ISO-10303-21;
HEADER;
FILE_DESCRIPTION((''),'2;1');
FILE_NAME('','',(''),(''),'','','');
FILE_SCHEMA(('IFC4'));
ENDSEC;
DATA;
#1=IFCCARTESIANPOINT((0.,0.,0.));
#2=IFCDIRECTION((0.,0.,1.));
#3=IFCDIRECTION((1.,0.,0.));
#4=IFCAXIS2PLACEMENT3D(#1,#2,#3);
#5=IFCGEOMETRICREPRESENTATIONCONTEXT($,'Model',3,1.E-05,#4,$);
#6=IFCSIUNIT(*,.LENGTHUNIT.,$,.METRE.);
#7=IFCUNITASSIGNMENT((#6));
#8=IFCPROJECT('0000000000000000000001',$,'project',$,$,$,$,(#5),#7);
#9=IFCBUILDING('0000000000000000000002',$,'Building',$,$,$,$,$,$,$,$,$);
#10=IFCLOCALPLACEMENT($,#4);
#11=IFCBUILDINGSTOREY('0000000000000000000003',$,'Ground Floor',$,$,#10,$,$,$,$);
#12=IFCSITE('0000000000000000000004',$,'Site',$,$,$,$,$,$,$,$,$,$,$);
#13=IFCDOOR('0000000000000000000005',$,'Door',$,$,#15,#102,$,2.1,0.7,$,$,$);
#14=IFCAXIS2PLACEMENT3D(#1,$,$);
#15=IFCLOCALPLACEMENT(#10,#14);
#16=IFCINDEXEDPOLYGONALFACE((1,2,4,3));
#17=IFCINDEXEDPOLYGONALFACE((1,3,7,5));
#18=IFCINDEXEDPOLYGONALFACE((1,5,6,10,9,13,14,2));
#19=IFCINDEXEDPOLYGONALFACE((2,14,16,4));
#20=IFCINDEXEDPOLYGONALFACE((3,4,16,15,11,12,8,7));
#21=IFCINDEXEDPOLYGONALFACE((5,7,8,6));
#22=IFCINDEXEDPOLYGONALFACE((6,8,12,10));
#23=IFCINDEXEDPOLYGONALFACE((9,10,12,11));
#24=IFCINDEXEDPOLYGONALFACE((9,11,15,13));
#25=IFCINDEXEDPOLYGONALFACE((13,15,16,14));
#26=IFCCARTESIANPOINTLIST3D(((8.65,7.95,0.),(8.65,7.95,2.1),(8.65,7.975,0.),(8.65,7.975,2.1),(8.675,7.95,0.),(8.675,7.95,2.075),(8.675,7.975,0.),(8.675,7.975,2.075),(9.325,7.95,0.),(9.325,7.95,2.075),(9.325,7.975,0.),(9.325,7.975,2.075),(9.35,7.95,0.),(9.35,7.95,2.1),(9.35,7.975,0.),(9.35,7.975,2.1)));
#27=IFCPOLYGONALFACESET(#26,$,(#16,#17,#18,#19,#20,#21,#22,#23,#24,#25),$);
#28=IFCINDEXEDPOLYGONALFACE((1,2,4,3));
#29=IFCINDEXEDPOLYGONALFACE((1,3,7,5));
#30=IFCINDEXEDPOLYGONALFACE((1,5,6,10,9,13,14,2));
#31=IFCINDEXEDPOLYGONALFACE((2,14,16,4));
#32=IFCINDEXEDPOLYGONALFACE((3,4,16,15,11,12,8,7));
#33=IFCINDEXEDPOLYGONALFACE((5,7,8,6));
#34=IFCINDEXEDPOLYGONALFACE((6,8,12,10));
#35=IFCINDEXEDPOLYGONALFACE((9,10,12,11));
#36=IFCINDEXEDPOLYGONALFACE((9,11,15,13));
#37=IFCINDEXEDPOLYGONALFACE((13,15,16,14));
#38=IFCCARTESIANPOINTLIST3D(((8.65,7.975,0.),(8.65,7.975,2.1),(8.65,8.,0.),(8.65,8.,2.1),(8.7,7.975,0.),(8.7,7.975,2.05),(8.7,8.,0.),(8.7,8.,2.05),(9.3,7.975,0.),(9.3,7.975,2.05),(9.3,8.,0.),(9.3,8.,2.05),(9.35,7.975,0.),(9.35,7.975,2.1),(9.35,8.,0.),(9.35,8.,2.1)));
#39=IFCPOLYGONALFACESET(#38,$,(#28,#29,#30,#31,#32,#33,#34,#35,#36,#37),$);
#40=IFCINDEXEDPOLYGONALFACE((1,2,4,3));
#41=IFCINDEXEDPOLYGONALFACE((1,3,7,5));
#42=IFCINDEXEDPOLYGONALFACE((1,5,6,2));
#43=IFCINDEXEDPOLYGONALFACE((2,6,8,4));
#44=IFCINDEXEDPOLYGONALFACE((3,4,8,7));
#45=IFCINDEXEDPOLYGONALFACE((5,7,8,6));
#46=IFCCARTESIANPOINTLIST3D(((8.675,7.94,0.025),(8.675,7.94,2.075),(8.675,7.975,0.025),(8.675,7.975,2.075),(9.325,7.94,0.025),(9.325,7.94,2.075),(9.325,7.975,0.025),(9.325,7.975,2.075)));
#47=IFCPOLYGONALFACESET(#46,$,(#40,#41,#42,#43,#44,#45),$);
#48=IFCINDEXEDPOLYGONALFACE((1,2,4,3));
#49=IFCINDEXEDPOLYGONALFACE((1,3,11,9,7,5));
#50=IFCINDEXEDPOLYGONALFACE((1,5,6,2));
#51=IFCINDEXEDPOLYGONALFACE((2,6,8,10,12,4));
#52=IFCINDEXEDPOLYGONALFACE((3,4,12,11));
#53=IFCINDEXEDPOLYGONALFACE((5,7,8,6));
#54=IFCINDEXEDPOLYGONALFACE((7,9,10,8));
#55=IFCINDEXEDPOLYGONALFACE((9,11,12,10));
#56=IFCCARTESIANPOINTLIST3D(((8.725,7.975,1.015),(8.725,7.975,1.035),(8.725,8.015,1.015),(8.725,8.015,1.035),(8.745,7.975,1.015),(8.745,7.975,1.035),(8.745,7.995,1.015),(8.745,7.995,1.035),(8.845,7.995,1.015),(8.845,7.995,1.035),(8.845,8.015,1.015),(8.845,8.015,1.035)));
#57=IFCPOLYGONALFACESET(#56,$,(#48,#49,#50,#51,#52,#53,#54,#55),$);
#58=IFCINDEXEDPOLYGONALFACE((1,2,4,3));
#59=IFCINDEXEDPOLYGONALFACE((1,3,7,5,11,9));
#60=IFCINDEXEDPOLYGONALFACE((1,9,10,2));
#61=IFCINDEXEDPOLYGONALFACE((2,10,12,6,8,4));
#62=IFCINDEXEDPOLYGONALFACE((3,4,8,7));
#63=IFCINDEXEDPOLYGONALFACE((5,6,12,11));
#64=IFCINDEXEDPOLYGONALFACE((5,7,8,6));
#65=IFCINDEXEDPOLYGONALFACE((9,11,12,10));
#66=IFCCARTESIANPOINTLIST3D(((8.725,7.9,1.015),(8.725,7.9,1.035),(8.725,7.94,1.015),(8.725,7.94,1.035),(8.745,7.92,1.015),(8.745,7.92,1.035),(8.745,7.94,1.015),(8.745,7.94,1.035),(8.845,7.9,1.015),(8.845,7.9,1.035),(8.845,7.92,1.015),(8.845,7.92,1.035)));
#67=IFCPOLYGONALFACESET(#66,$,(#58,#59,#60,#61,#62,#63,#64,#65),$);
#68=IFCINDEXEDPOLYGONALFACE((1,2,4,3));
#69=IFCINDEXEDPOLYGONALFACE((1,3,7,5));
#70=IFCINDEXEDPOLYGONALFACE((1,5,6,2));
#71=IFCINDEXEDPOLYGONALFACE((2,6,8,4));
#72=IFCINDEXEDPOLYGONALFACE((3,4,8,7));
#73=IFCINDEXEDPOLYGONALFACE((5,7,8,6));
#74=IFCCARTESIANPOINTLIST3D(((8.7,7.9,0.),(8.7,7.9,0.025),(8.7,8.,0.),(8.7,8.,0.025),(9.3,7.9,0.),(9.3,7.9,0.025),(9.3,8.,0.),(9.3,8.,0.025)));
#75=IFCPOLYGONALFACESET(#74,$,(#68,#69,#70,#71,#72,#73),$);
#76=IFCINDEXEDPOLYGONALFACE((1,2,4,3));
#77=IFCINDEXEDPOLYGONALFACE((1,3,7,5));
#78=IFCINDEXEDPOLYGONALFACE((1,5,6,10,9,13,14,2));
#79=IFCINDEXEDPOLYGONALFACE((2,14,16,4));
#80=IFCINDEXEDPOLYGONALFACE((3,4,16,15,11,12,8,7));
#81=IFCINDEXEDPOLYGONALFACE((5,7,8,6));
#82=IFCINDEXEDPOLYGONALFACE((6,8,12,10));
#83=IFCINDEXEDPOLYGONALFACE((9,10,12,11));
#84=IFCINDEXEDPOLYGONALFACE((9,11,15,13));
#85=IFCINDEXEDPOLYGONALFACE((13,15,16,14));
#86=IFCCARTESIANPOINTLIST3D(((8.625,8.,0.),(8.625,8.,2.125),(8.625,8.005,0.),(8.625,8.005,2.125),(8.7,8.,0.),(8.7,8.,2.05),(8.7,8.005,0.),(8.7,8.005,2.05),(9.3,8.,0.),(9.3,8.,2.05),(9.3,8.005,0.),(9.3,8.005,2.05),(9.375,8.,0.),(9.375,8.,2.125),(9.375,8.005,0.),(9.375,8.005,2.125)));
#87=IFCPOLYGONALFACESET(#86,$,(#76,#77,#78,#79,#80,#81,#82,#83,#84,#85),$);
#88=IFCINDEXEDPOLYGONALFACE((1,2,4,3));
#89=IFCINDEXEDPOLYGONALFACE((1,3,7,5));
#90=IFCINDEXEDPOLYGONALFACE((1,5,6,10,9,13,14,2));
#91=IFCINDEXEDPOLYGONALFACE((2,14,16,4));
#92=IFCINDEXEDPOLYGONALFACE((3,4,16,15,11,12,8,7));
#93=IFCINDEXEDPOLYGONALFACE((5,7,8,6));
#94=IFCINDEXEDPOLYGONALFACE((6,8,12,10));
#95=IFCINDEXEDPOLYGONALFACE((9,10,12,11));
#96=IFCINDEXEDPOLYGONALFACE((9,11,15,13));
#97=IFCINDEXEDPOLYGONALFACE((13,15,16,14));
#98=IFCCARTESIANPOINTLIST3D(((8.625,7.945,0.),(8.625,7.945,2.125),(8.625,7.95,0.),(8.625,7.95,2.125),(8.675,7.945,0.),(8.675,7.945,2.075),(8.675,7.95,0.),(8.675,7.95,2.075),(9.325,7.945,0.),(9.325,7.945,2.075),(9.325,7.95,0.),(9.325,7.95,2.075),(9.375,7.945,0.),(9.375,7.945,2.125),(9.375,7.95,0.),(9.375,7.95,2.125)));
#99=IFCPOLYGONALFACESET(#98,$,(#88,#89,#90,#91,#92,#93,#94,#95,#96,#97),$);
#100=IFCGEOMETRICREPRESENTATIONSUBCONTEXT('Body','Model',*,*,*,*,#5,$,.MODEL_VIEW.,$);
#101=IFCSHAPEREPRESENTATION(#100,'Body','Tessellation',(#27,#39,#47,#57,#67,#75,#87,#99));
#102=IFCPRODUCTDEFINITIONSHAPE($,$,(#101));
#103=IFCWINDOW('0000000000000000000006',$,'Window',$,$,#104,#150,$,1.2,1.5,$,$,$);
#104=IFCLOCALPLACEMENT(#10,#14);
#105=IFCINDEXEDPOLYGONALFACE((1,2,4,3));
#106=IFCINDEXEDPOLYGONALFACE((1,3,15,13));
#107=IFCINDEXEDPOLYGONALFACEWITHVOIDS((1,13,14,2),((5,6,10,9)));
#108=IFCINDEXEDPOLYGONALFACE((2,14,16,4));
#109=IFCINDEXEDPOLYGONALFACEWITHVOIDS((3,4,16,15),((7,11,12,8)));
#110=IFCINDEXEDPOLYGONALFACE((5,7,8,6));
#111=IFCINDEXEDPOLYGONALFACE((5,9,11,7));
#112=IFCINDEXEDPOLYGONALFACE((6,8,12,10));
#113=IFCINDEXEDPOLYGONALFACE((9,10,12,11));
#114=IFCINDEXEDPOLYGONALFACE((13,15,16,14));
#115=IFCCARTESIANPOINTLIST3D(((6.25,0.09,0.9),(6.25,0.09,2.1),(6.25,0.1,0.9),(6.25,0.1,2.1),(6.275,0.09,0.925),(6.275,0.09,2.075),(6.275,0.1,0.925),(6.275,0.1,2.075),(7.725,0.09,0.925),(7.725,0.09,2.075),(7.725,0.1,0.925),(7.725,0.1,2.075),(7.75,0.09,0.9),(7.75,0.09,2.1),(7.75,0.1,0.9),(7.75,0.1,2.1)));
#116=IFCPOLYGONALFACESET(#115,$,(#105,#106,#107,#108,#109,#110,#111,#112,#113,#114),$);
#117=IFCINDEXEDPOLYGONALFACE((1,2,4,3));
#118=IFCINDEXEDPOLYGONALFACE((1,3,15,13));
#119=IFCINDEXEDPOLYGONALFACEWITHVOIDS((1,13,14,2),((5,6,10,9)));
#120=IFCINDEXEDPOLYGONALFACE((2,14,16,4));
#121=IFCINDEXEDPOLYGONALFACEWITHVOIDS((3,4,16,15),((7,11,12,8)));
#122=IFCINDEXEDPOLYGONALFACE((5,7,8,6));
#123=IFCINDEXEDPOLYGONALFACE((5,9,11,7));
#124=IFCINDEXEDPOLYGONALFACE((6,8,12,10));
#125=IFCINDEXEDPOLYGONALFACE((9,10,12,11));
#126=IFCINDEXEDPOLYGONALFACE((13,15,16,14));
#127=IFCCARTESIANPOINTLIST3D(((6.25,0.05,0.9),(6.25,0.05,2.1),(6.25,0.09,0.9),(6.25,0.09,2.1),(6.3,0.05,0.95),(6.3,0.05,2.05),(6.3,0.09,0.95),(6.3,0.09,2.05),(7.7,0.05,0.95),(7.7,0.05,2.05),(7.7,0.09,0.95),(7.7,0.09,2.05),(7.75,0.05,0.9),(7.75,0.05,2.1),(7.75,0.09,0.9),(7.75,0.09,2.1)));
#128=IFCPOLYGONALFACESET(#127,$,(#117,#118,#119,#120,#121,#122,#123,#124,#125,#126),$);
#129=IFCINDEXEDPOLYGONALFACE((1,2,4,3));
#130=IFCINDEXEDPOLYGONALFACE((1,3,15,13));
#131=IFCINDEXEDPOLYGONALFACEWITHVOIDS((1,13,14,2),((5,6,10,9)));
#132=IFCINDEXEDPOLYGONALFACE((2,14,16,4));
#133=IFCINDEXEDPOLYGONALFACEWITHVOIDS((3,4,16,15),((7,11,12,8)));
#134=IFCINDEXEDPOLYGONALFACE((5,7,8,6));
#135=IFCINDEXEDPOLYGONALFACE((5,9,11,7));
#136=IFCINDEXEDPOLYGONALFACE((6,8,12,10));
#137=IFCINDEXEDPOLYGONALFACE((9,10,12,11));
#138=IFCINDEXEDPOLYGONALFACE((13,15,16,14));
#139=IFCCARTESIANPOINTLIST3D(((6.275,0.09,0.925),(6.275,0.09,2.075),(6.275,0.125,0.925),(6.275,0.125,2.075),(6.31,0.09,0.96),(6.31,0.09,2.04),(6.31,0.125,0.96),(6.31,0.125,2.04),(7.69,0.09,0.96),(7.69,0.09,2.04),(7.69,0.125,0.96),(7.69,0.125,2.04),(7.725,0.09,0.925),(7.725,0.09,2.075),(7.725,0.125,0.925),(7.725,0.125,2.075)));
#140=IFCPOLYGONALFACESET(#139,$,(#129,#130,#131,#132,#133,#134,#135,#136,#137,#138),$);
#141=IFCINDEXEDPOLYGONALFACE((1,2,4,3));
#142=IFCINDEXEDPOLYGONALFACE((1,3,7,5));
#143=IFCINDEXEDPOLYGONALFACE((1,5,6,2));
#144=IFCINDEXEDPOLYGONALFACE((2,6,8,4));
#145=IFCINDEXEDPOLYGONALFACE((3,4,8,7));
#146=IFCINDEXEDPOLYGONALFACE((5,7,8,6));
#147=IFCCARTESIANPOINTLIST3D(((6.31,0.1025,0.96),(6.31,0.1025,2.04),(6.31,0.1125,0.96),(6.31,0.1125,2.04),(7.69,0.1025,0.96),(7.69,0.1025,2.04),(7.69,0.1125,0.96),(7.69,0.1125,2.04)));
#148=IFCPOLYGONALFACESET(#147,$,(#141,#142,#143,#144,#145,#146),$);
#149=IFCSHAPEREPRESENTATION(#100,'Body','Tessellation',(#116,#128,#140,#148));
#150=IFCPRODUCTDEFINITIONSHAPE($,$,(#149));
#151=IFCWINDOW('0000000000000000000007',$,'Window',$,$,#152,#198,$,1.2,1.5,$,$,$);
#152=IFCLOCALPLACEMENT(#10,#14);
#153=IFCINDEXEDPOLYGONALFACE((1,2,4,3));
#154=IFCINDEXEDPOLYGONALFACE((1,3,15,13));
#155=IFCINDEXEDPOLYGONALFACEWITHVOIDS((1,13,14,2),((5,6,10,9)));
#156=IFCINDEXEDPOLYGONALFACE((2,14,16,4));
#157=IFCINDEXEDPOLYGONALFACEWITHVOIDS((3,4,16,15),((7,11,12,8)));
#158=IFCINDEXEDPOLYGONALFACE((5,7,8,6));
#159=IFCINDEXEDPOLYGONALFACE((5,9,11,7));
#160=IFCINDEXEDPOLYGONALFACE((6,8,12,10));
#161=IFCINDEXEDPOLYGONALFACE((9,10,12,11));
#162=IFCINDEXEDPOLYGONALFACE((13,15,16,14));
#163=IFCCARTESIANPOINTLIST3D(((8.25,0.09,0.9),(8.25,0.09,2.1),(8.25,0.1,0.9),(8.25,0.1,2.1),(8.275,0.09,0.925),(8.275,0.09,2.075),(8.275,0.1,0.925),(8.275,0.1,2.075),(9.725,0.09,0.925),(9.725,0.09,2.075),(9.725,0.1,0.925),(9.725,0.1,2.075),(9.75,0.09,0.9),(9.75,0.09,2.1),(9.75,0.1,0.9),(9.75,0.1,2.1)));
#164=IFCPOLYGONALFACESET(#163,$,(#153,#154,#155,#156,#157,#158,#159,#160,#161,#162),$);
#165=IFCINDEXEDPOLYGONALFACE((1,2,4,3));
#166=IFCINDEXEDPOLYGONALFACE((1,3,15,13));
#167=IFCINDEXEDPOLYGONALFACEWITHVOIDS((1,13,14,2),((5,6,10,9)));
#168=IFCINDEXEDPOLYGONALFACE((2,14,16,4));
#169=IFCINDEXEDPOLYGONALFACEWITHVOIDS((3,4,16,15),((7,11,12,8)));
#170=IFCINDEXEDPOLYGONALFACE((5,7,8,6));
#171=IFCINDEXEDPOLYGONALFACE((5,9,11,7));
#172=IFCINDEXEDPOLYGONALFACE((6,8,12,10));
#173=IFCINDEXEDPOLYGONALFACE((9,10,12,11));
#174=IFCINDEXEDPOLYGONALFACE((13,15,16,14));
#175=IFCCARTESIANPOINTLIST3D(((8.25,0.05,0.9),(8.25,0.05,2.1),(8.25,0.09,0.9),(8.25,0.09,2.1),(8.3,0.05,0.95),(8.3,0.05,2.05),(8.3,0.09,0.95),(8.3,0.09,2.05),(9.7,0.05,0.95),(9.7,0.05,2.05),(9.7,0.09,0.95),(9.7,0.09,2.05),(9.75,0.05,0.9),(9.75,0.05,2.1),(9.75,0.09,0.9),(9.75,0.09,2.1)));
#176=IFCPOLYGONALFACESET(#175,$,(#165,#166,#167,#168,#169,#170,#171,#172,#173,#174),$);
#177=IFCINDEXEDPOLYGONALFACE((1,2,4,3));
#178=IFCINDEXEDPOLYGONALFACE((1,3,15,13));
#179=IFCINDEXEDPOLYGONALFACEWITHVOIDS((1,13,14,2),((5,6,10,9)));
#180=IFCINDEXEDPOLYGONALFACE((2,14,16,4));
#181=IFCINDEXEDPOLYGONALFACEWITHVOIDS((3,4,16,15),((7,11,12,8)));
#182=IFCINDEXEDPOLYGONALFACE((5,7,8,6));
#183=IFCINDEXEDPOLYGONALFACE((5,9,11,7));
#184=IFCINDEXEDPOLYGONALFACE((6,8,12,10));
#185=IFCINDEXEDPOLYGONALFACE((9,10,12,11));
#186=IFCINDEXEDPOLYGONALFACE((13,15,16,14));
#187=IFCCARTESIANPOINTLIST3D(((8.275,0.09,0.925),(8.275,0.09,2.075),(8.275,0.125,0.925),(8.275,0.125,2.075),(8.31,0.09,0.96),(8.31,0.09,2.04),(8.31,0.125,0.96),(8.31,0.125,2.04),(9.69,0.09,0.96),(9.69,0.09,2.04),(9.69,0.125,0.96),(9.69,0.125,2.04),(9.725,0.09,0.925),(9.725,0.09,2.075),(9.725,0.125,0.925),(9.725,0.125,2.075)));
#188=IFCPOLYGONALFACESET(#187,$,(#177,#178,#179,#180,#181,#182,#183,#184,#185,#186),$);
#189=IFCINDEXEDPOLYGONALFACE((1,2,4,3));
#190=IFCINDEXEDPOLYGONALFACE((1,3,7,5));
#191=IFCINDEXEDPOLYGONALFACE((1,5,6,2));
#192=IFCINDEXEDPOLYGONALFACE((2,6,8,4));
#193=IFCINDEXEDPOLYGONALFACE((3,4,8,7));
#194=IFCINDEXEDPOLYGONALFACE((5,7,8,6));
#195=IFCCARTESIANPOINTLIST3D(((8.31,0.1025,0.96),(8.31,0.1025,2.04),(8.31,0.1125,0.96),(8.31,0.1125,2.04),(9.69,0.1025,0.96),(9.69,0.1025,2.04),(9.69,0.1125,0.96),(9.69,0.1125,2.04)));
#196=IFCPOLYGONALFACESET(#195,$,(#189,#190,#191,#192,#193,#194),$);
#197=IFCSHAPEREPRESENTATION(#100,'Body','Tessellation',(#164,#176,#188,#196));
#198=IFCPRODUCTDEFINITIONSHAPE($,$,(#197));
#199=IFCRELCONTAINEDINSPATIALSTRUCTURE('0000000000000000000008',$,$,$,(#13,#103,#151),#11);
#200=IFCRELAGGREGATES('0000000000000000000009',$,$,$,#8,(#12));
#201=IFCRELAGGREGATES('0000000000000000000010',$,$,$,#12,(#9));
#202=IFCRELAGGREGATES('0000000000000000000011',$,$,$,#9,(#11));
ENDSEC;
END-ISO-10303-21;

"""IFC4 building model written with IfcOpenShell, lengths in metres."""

from ifc_helpers import new_model, si_unit, frame, origin_with_axes, place, context, subcontext, project, spatial, line, indexed_curve, outline, extrude, element, save


model = new_model("IFC4")

# Units and contexts
model_context = context("Model", 3, precision=1e-05, world=origin_with_axes())
body_context = subcontext(model_context, "Body", "Model", "MODEL_VIEW")
ifc_project = project(units=[si_unit("LENGTHUNIT", "METRE")], contexts=[model_context])

# Site, building, storey
site = spatial("IfcSite", under=ifc_project, Name="Site")
building = spatial("IfcBuilding", under=site, Name="Building")
storey_placement = place(None, origin_with_axes())
storey = spatial("IfcBuildingStorey", under=building, at=storey_placement, Name="Ground Floor")

# Door
door_1_placement = place(storey_placement, frame((9.35, 8.0, 0.0), z_axis=(0.0, 0.0, 1.0), x_axis=(-1.0, 0.0, 0.0)))
element("IfcDoor", 1, at=door_1_placement, inside=storey, Name="Door", OverallHeight=2.1, OverallWidth=0.7, context=body_context, shape_type="SweptSolid", body=[
    extrude(outline(indexed_curve([(0.0, 0.0), (0.0, 2.1), (0.7, 2.1), (0.7, 0.0), (0.675, 0.0), (0.675, 2.075), (0.025, 2.075), (0.025, 0.0)], segments=[line(1, 2, 3, 4, 5, 6, 7, 8, 1)])), frame((0.0, 0.025, 0.0), z_axis=(0.0, -1.0, 0.0), x_axis=(1.0, 0.0, 0.0)), (0.0, 0.0, -1.0), 0.025),
    extrude(outline(indexed_curve([(0.0, 0.0), (0.0, 2.1), (0.7, 2.1), (0.7, 0.0), (0.65, 0.0), (0.65, 2.05), (0.05, 2.05), (0.05, 0.0)], segments=[line(1, 2, 3, 4, 5, 6, 7, 8, 1)])), frame((0.0, 0.0, 0.0), z_axis=(0.0, -1.0, 0.0), x_axis=(1.0, 0.0, 0.0)), (0.0, 0.0, -1.0), 0.025),
    extrude(outline(indexed_curve([(0.0, 0.0), (0.65, 0.0), (0.65, 0.035), (0.0, 0.035)], segments=[line(1, 2, 3, 4, 1)])), frame((0.025, 0.025, 0.025), z_axis=(0.0, 0.0, 1.0), x_axis=(1.0, 0.0, 0.0)), (0.0, 0.0, 1.0), 2.05),
    extrude(outline(indexed_curve([(0.0, 0.0), (0.0, -0.04), (-0.12, -0.04), (-0.12, -0.02), (-0.02, -0.02), (-0.02, 0.0)], segments=[line(1, 2, 3, 4, 5, 6, 1)])), frame((0.625, 0.025, 1.015), z_axis=(0.0, 0.0, 1.0), x_axis=(1.0, 0.0, 0.0)), (0.0, 0.0, 1.0), 0.02),
    extrude(outline(indexed_curve([(0.0, 0.0), (0.0, 0.04), (-0.12, 0.04), (-0.12, 0.02), (-0.02, 0.02), (-0.02, 0.0)], segments=[line(1, 2, 3, 4, 5, 6, 1)])), frame((0.625, 0.06, 1.015), z_axis=(0.0, 0.0, 1.0), x_axis=(1.0, 0.0, 0.0)), (0.0, 0.0, 1.0), 0.02),
    extrude(outline(indexed_curve([(0.0, 0.0), (0.6, 0.0), (0.6, 0.1), (0.0, 0.1)], segments=[line(1, 2, 3, 4, 1)])), frame((0.05, 0.0, 0.0), z_axis=(0.0, 0.0, 1.0), x_axis=(1.0, 0.0, 0.0)), (0.0, 0.0, 1.0), 0.025),
    extrude(outline(indexed_curve([(0.0, 0.0), (0.0, 2.125), (0.75, 2.125), (0.75, 0.0), (0.675, 0.0), (0.675, 2.05), (0.075, 2.05), (0.075, 0.0)], segments=[line(1, 2, 3, 4, 5, 6, 7, 8, 1)])), frame((-0.025, -0.005, 0.0), z_axis=(0.0, -1.0, 0.0), x_axis=(1.0, 0.0, 0.0)), (0.0, 0.0, -1.0), 0.005),
    extrude(outline(indexed_curve([(0.0, 0.0), (0.0, 2.125), (0.75, 2.125), (0.75, 0.0), (0.7, 0.0), (0.7, 2.075), (0.05, 2.075), (0.05, 0.0)], segments=[line(1, 2, 3, 4, 5, 6, 7, 8, 1)])), frame((-0.025, 0.05, 0.0), z_axis=(0.0, -1.0, 0.0), x_axis=(1.0, 0.0, 0.0)), (0.0, 0.0, -1.0), 0.005),
])

# Windows
for number, where, z_axis, x_axis, name in (
    (2, (6.25, 0.0, 0.9), (0.0, 0.0, 1.0), (1.0, 0.0, 0.0), "Window"),
    (3, (8.25, 0.0, 0.9), (0.0, 0.0, 1.0), (1.0, 0.0, 0.0), "Window"),
):
    element("IfcWindow", number, at=place(storey_placement, frame(where, z_axis=z_axis, x_axis=x_axis)), inside=storey, Name=name, OverallHeight=1.2, OverallWidth=1.5, context=body_context, shape_type="SweptSolid", body=[
        extrude(outline(indexed_curve([(0.0, 0.0), (1.5, 0.0), (1.5, 1.2), (0.0, 1.2)], segments=[line(1, 2, 3, 4, 1)]), holes=[indexed_curve([(0.025, 0.025), (1.475, 0.025), (1.475, 1.175), (0.025, 1.175)], segments=[line(1, 2, 3, 4, 1)])]), frame((0.0, 0.09, 0.0), z_axis=(0.0, -1.0, 0.0), x_axis=(1.0, 0.0, 0.0)), (0.0, 0.0, -1.0), 0.01),
        extrude(outline(indexed_curve([(0.0, 0.0), (1.5, 0.0), (1.5, 1.2), (0.0, 1.2)], segments=[line(1, 2, 3, 4, 1)]), holes=[indexed_curve([(0.05, 0.05), (1.45, 0.05), (1.45, 1.15), (0.05, 1.15)], segments=[line(1, 2, 3, 4, 1)])]), frame((0.0, 0.05, 0.0), z_axis=(0.0, -1.0, 0.0), x_axis=(1.0, 0.0, 0.0)), (0.0, 0.0, -1.0), 0.04),
        extrude(outline(indexed_curve([(0.0, 0.0), (1.45, 0.0), (1.45, 1.15), (0.0, 1.15)], segments=[line(1, 2, 3, 4, 1)]), holes=[indexed_curve([(0.035, 0.035), (1.415, 0.035), (1.415, 1.115), (0.035, 1.115)], segments=[line(1, 2, 3, 4, 1)])]), frame((0.025, 0.09, 0.025), z_axis=(0.0, -1.0, 0.0), x_axis=(1.0, 0.0, 0.0)), (0.0, 0.0, -1.0), 0.035),
        extrude(outline(indexed_curve([(0.035, 0.035), (1.415, 0.035), (1.415, 1.115), (0.035, 1.115)], segments=[line(1, 2, 3, 4, 1)])), frame((0.025, 0.1025, 0.025), z_axis=(0.0, -1.0, 0.0), x_axis=(1.0, 0.0, 0.0)), (0.0, 0.0, -1.0), 0.01),
    ])

save(model, "model.ifc")
